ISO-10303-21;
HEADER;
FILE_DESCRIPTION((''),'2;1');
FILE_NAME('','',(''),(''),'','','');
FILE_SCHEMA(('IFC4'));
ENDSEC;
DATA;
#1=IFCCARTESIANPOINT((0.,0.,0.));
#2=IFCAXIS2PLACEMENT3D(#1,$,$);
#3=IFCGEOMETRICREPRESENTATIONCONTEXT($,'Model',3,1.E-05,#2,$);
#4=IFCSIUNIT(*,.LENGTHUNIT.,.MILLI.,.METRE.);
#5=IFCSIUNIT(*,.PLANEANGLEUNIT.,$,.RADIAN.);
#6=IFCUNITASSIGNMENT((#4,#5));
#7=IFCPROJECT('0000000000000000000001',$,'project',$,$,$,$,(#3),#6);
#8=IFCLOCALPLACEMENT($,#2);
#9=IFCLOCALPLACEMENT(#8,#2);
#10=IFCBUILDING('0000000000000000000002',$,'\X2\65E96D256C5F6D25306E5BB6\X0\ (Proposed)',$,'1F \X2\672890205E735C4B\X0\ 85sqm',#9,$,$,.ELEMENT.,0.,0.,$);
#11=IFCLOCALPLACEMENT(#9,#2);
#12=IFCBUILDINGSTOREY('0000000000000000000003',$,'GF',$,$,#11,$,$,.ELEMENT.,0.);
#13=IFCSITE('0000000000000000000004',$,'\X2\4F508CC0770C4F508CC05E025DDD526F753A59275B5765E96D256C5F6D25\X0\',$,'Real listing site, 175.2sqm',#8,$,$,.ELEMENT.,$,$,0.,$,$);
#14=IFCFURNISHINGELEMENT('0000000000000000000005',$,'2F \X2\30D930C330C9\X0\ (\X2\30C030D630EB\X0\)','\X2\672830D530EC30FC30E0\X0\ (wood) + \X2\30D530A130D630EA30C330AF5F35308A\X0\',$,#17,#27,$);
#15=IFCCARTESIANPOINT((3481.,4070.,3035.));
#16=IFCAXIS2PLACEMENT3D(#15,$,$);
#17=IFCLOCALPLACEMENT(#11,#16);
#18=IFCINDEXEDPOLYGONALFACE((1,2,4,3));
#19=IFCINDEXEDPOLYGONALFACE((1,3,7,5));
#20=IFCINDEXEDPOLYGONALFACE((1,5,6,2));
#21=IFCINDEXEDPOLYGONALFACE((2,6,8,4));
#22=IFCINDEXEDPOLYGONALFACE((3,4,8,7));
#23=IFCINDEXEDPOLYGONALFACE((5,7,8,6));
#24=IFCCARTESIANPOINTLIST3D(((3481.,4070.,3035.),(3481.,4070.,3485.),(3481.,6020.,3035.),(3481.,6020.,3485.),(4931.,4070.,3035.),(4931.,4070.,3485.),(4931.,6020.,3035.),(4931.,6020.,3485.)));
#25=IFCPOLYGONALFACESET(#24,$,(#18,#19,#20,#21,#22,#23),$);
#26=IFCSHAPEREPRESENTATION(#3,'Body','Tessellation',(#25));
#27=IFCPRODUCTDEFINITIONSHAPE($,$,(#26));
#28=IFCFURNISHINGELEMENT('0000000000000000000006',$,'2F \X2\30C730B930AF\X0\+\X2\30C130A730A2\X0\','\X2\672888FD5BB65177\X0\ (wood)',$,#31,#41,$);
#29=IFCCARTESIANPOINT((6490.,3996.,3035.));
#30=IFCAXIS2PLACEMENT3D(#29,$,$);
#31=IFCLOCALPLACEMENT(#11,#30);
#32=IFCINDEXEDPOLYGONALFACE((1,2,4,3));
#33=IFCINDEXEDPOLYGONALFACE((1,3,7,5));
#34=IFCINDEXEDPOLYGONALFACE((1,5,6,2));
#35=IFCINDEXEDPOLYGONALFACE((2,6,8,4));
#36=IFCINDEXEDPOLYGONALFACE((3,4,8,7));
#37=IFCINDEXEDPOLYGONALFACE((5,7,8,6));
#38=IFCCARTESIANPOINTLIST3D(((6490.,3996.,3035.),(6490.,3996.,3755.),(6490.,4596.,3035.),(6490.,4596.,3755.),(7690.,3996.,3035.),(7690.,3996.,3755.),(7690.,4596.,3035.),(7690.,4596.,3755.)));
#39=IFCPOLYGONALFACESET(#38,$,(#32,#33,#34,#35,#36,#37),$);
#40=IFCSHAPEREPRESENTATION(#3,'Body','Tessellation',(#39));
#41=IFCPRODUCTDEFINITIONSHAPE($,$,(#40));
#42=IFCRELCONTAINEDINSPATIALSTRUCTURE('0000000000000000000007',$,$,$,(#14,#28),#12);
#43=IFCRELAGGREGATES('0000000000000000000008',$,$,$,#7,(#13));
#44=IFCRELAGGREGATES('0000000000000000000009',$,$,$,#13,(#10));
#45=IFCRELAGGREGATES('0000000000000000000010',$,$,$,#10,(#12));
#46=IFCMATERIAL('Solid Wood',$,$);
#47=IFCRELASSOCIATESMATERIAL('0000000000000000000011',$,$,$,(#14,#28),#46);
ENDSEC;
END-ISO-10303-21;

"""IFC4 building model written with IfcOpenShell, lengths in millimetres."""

from ifc_helpers import new_model, si_unit, frame, frame_2d, origin, place, context, project, spatial, rectangle, extrude, material, element, save


model = new_model("IFC4")

# Units and contexts
model_context = context("Model", 3, precision=1e-05, world=origin())
ifc_project = project(units=[si_unit("LENGTHUNIT", "METRE", prefix="MILLI"), si_unit("PLANEANGLEUNIT", "RADIAN")], contexts=[model_context])

# Site, building, storey
site_placement = place(None, origin())
site = spatial("IfcSite", under=ifc_project, at=site_placement, Name="佐賀県佐賀市川副町大字早津江津", ObjectType="Real listing site, 175.2sqm", CompositionType="ELEMENT", RefElevation=0.0)
building_placement = place(site_placement, origin())
building = spatial("IfcBuilding", under=site, at=building_placement, Name="早津江津の家 (Proposed)", ObjectType="1F 木造平屋 85sqm", CompositionType="ELEMENT", ElevationOfRefHeight=0.0, ElevationOfTerrain=0.0)
storey_placement = place(building_placement, origin())
storey = spatial("IfcBuildingStorey", under=building, at=storey_placement, Name="GF", CompositionType="ELEMENT", Elevation=0.0)

# Shared definitions
ifc_material_1 = material(Name="Solid Wood")

# Furnishing elements
furnishing_1_placement = place(storey_placement, frame((3481.0, 4070.0, 3035.0)))
element("IfcFurnishingElement", 1, at=furnishing_1_placement, inside=storey, material=ifc_material_1, Name="2F ベッド (ダブル)", Description="木フレーム (wood) + ファブリック張り", context=model_context, shape_type="SweptSolid", body=[
    extrude(rectangle(XDim=1450.0, YDim=1950.0, at=frame_2d((725.0, 975.0))), frame((3481.0, 4070.0, 3035.0)), (0.0, 0.0, 1.0), 450.0),
])
furnishing_2_placement = place(storey_placement, frame((6490.0, 3996.0, 3035.0)))
element("IfcFurnishingElement", 2, at=furnishing_2_placement, inside=storey, material=ifc_material_1, Name="2F デスク+チェア", Description="木製家具 (wood)", context=model_context, shape_type="SweptSolid", body=[
    extrude(rectangle(XDim=1200.0, YDim=600.0, at=frame_2d((600.0, 300.0))), frame((6490.0, 3996.0, 3035.0)), (0.0, 0.0, 1.0), 720.0),
])

save(model, "model.ifc")
